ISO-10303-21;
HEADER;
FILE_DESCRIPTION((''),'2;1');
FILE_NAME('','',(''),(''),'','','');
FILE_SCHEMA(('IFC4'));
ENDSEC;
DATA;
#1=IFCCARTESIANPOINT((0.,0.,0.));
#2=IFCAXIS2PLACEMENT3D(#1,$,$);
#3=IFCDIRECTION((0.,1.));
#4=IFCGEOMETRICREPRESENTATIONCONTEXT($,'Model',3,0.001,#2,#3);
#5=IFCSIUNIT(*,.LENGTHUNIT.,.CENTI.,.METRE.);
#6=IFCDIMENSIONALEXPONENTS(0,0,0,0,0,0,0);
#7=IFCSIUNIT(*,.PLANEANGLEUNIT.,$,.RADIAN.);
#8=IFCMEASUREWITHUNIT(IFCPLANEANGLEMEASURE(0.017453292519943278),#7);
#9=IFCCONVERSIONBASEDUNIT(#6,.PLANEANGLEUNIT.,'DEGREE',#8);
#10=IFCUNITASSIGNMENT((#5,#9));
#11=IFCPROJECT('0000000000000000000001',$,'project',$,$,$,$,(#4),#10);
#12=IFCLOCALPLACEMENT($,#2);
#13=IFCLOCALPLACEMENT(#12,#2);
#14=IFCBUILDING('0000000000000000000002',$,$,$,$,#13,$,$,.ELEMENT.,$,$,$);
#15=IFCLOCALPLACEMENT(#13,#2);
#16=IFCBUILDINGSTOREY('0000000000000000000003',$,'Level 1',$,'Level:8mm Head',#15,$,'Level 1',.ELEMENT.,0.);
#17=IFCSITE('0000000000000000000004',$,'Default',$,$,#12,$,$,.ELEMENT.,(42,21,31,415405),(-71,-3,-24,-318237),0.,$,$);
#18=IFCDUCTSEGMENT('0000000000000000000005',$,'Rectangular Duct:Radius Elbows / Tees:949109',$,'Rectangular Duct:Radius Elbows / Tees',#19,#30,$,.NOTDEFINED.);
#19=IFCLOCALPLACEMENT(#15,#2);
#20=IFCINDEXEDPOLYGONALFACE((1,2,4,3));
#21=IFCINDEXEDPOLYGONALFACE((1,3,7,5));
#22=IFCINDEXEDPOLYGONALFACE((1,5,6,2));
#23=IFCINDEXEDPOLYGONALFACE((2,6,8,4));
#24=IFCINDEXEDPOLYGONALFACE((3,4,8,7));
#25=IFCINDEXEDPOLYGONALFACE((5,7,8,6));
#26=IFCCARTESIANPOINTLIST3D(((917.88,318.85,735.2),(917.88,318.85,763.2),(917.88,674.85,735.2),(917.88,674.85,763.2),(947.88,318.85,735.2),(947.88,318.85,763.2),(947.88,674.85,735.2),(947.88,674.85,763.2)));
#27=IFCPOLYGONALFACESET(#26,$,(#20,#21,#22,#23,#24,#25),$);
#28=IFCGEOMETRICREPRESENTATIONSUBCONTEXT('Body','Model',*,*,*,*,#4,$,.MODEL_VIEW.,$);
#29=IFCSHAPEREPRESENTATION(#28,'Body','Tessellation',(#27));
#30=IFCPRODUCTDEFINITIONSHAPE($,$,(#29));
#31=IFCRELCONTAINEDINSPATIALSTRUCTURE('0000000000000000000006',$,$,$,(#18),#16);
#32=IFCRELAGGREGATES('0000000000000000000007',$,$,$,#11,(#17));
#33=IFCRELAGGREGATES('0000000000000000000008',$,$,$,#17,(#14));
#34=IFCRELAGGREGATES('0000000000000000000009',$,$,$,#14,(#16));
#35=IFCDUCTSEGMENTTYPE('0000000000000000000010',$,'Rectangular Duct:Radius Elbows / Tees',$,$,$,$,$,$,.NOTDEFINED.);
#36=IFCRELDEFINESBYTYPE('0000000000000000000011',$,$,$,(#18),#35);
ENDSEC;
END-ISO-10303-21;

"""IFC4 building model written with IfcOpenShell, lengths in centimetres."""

from ifc_helpers import new_model, entity, si_unit, converted_unit, direction, frame, origin, place, context, subcontext, project, spatial, indexed_curve, outline, extrude, type_object, element, save


model = new_model("IFC4")

# Units and contexts
model_context = context("Model", 3, precision=0.001, world=origin(), true_north=direction((0.0, 1.0)))
body_context = subcontext(model_context, "Body", "Model", "MODEL_VIEW")
ifc_project = project(units=[si_unit("LENGTHUNIT", "METRE", prefix="CENTI"), converted_unit("PLANEANGLEUNIT", "DEGREE", entity("IfcPlaneAngleMeasure", 0.017453292519943278), si_unit("PLANEANGLEUNIT", "RADIAN"), dimensions=[0, 0, 0, 0, 0, 0, 0])], contexts=[model_context])

# Site, building, storey
site_placement = place(None, origin())
site = spatial("IfcSite", under=ifc_project, at=site_placement, Name="Default", CompositionType="ELEMENT", RefLatitude=(42, 21, 31, 415405), RefLongitude=(-71, -3, -24, -318237), RefElevation=0.0)
building_placement = place(site_placement, origin())
building = spatial("IfcBuilding", under=site, at=building_placement, CompositionType="ELEMENT")
storey_placement = place(building_placement, origin())
storey = spatial("IfcBuildingStorey", under=building, at=storey_placement, Name="Level 1", ObjectType="Level:8mm Head", LongName="Level 1", CompositionType="ELEMENT", Elevation=0.0)

# Duct segment
duct_segment_type = type_object("IfcDuctSegmentType", Name="Rectangular Duct:Radius Elbows / Tees", PredefinedType="NOTDEFINED")
duct_segment_1_placement = place(storey_placement, origin())
element("IfcDuctSegment", 1, at=duct_segment_1_placement, inside=storey, type_object=duct_segment_type, Name="Rectangular Duct:Radius Elbows / Tees:949109", ObjectType="Rectangular Duct:Radius Elbows / Tees", PredefinedType="NOTDEFINED", context=body_context, shape_type="SweptSolid", body=[
    extrude(outline(indexed_curve([(-178.0, -15.0), (178.0, -15.0), (178.0, 15.0), (-178.0, 15.0), (-178.0, -15.0)], self_intersect=False)), frame((932.88, 496.85, 735.2), z_axis=(0.0, 0.0, 1.0), x_axis=(0.0, 1.0, 0.0)), (0.0, 0.0, 1.0), 28.0),
])

save(model, "model.ifc")
